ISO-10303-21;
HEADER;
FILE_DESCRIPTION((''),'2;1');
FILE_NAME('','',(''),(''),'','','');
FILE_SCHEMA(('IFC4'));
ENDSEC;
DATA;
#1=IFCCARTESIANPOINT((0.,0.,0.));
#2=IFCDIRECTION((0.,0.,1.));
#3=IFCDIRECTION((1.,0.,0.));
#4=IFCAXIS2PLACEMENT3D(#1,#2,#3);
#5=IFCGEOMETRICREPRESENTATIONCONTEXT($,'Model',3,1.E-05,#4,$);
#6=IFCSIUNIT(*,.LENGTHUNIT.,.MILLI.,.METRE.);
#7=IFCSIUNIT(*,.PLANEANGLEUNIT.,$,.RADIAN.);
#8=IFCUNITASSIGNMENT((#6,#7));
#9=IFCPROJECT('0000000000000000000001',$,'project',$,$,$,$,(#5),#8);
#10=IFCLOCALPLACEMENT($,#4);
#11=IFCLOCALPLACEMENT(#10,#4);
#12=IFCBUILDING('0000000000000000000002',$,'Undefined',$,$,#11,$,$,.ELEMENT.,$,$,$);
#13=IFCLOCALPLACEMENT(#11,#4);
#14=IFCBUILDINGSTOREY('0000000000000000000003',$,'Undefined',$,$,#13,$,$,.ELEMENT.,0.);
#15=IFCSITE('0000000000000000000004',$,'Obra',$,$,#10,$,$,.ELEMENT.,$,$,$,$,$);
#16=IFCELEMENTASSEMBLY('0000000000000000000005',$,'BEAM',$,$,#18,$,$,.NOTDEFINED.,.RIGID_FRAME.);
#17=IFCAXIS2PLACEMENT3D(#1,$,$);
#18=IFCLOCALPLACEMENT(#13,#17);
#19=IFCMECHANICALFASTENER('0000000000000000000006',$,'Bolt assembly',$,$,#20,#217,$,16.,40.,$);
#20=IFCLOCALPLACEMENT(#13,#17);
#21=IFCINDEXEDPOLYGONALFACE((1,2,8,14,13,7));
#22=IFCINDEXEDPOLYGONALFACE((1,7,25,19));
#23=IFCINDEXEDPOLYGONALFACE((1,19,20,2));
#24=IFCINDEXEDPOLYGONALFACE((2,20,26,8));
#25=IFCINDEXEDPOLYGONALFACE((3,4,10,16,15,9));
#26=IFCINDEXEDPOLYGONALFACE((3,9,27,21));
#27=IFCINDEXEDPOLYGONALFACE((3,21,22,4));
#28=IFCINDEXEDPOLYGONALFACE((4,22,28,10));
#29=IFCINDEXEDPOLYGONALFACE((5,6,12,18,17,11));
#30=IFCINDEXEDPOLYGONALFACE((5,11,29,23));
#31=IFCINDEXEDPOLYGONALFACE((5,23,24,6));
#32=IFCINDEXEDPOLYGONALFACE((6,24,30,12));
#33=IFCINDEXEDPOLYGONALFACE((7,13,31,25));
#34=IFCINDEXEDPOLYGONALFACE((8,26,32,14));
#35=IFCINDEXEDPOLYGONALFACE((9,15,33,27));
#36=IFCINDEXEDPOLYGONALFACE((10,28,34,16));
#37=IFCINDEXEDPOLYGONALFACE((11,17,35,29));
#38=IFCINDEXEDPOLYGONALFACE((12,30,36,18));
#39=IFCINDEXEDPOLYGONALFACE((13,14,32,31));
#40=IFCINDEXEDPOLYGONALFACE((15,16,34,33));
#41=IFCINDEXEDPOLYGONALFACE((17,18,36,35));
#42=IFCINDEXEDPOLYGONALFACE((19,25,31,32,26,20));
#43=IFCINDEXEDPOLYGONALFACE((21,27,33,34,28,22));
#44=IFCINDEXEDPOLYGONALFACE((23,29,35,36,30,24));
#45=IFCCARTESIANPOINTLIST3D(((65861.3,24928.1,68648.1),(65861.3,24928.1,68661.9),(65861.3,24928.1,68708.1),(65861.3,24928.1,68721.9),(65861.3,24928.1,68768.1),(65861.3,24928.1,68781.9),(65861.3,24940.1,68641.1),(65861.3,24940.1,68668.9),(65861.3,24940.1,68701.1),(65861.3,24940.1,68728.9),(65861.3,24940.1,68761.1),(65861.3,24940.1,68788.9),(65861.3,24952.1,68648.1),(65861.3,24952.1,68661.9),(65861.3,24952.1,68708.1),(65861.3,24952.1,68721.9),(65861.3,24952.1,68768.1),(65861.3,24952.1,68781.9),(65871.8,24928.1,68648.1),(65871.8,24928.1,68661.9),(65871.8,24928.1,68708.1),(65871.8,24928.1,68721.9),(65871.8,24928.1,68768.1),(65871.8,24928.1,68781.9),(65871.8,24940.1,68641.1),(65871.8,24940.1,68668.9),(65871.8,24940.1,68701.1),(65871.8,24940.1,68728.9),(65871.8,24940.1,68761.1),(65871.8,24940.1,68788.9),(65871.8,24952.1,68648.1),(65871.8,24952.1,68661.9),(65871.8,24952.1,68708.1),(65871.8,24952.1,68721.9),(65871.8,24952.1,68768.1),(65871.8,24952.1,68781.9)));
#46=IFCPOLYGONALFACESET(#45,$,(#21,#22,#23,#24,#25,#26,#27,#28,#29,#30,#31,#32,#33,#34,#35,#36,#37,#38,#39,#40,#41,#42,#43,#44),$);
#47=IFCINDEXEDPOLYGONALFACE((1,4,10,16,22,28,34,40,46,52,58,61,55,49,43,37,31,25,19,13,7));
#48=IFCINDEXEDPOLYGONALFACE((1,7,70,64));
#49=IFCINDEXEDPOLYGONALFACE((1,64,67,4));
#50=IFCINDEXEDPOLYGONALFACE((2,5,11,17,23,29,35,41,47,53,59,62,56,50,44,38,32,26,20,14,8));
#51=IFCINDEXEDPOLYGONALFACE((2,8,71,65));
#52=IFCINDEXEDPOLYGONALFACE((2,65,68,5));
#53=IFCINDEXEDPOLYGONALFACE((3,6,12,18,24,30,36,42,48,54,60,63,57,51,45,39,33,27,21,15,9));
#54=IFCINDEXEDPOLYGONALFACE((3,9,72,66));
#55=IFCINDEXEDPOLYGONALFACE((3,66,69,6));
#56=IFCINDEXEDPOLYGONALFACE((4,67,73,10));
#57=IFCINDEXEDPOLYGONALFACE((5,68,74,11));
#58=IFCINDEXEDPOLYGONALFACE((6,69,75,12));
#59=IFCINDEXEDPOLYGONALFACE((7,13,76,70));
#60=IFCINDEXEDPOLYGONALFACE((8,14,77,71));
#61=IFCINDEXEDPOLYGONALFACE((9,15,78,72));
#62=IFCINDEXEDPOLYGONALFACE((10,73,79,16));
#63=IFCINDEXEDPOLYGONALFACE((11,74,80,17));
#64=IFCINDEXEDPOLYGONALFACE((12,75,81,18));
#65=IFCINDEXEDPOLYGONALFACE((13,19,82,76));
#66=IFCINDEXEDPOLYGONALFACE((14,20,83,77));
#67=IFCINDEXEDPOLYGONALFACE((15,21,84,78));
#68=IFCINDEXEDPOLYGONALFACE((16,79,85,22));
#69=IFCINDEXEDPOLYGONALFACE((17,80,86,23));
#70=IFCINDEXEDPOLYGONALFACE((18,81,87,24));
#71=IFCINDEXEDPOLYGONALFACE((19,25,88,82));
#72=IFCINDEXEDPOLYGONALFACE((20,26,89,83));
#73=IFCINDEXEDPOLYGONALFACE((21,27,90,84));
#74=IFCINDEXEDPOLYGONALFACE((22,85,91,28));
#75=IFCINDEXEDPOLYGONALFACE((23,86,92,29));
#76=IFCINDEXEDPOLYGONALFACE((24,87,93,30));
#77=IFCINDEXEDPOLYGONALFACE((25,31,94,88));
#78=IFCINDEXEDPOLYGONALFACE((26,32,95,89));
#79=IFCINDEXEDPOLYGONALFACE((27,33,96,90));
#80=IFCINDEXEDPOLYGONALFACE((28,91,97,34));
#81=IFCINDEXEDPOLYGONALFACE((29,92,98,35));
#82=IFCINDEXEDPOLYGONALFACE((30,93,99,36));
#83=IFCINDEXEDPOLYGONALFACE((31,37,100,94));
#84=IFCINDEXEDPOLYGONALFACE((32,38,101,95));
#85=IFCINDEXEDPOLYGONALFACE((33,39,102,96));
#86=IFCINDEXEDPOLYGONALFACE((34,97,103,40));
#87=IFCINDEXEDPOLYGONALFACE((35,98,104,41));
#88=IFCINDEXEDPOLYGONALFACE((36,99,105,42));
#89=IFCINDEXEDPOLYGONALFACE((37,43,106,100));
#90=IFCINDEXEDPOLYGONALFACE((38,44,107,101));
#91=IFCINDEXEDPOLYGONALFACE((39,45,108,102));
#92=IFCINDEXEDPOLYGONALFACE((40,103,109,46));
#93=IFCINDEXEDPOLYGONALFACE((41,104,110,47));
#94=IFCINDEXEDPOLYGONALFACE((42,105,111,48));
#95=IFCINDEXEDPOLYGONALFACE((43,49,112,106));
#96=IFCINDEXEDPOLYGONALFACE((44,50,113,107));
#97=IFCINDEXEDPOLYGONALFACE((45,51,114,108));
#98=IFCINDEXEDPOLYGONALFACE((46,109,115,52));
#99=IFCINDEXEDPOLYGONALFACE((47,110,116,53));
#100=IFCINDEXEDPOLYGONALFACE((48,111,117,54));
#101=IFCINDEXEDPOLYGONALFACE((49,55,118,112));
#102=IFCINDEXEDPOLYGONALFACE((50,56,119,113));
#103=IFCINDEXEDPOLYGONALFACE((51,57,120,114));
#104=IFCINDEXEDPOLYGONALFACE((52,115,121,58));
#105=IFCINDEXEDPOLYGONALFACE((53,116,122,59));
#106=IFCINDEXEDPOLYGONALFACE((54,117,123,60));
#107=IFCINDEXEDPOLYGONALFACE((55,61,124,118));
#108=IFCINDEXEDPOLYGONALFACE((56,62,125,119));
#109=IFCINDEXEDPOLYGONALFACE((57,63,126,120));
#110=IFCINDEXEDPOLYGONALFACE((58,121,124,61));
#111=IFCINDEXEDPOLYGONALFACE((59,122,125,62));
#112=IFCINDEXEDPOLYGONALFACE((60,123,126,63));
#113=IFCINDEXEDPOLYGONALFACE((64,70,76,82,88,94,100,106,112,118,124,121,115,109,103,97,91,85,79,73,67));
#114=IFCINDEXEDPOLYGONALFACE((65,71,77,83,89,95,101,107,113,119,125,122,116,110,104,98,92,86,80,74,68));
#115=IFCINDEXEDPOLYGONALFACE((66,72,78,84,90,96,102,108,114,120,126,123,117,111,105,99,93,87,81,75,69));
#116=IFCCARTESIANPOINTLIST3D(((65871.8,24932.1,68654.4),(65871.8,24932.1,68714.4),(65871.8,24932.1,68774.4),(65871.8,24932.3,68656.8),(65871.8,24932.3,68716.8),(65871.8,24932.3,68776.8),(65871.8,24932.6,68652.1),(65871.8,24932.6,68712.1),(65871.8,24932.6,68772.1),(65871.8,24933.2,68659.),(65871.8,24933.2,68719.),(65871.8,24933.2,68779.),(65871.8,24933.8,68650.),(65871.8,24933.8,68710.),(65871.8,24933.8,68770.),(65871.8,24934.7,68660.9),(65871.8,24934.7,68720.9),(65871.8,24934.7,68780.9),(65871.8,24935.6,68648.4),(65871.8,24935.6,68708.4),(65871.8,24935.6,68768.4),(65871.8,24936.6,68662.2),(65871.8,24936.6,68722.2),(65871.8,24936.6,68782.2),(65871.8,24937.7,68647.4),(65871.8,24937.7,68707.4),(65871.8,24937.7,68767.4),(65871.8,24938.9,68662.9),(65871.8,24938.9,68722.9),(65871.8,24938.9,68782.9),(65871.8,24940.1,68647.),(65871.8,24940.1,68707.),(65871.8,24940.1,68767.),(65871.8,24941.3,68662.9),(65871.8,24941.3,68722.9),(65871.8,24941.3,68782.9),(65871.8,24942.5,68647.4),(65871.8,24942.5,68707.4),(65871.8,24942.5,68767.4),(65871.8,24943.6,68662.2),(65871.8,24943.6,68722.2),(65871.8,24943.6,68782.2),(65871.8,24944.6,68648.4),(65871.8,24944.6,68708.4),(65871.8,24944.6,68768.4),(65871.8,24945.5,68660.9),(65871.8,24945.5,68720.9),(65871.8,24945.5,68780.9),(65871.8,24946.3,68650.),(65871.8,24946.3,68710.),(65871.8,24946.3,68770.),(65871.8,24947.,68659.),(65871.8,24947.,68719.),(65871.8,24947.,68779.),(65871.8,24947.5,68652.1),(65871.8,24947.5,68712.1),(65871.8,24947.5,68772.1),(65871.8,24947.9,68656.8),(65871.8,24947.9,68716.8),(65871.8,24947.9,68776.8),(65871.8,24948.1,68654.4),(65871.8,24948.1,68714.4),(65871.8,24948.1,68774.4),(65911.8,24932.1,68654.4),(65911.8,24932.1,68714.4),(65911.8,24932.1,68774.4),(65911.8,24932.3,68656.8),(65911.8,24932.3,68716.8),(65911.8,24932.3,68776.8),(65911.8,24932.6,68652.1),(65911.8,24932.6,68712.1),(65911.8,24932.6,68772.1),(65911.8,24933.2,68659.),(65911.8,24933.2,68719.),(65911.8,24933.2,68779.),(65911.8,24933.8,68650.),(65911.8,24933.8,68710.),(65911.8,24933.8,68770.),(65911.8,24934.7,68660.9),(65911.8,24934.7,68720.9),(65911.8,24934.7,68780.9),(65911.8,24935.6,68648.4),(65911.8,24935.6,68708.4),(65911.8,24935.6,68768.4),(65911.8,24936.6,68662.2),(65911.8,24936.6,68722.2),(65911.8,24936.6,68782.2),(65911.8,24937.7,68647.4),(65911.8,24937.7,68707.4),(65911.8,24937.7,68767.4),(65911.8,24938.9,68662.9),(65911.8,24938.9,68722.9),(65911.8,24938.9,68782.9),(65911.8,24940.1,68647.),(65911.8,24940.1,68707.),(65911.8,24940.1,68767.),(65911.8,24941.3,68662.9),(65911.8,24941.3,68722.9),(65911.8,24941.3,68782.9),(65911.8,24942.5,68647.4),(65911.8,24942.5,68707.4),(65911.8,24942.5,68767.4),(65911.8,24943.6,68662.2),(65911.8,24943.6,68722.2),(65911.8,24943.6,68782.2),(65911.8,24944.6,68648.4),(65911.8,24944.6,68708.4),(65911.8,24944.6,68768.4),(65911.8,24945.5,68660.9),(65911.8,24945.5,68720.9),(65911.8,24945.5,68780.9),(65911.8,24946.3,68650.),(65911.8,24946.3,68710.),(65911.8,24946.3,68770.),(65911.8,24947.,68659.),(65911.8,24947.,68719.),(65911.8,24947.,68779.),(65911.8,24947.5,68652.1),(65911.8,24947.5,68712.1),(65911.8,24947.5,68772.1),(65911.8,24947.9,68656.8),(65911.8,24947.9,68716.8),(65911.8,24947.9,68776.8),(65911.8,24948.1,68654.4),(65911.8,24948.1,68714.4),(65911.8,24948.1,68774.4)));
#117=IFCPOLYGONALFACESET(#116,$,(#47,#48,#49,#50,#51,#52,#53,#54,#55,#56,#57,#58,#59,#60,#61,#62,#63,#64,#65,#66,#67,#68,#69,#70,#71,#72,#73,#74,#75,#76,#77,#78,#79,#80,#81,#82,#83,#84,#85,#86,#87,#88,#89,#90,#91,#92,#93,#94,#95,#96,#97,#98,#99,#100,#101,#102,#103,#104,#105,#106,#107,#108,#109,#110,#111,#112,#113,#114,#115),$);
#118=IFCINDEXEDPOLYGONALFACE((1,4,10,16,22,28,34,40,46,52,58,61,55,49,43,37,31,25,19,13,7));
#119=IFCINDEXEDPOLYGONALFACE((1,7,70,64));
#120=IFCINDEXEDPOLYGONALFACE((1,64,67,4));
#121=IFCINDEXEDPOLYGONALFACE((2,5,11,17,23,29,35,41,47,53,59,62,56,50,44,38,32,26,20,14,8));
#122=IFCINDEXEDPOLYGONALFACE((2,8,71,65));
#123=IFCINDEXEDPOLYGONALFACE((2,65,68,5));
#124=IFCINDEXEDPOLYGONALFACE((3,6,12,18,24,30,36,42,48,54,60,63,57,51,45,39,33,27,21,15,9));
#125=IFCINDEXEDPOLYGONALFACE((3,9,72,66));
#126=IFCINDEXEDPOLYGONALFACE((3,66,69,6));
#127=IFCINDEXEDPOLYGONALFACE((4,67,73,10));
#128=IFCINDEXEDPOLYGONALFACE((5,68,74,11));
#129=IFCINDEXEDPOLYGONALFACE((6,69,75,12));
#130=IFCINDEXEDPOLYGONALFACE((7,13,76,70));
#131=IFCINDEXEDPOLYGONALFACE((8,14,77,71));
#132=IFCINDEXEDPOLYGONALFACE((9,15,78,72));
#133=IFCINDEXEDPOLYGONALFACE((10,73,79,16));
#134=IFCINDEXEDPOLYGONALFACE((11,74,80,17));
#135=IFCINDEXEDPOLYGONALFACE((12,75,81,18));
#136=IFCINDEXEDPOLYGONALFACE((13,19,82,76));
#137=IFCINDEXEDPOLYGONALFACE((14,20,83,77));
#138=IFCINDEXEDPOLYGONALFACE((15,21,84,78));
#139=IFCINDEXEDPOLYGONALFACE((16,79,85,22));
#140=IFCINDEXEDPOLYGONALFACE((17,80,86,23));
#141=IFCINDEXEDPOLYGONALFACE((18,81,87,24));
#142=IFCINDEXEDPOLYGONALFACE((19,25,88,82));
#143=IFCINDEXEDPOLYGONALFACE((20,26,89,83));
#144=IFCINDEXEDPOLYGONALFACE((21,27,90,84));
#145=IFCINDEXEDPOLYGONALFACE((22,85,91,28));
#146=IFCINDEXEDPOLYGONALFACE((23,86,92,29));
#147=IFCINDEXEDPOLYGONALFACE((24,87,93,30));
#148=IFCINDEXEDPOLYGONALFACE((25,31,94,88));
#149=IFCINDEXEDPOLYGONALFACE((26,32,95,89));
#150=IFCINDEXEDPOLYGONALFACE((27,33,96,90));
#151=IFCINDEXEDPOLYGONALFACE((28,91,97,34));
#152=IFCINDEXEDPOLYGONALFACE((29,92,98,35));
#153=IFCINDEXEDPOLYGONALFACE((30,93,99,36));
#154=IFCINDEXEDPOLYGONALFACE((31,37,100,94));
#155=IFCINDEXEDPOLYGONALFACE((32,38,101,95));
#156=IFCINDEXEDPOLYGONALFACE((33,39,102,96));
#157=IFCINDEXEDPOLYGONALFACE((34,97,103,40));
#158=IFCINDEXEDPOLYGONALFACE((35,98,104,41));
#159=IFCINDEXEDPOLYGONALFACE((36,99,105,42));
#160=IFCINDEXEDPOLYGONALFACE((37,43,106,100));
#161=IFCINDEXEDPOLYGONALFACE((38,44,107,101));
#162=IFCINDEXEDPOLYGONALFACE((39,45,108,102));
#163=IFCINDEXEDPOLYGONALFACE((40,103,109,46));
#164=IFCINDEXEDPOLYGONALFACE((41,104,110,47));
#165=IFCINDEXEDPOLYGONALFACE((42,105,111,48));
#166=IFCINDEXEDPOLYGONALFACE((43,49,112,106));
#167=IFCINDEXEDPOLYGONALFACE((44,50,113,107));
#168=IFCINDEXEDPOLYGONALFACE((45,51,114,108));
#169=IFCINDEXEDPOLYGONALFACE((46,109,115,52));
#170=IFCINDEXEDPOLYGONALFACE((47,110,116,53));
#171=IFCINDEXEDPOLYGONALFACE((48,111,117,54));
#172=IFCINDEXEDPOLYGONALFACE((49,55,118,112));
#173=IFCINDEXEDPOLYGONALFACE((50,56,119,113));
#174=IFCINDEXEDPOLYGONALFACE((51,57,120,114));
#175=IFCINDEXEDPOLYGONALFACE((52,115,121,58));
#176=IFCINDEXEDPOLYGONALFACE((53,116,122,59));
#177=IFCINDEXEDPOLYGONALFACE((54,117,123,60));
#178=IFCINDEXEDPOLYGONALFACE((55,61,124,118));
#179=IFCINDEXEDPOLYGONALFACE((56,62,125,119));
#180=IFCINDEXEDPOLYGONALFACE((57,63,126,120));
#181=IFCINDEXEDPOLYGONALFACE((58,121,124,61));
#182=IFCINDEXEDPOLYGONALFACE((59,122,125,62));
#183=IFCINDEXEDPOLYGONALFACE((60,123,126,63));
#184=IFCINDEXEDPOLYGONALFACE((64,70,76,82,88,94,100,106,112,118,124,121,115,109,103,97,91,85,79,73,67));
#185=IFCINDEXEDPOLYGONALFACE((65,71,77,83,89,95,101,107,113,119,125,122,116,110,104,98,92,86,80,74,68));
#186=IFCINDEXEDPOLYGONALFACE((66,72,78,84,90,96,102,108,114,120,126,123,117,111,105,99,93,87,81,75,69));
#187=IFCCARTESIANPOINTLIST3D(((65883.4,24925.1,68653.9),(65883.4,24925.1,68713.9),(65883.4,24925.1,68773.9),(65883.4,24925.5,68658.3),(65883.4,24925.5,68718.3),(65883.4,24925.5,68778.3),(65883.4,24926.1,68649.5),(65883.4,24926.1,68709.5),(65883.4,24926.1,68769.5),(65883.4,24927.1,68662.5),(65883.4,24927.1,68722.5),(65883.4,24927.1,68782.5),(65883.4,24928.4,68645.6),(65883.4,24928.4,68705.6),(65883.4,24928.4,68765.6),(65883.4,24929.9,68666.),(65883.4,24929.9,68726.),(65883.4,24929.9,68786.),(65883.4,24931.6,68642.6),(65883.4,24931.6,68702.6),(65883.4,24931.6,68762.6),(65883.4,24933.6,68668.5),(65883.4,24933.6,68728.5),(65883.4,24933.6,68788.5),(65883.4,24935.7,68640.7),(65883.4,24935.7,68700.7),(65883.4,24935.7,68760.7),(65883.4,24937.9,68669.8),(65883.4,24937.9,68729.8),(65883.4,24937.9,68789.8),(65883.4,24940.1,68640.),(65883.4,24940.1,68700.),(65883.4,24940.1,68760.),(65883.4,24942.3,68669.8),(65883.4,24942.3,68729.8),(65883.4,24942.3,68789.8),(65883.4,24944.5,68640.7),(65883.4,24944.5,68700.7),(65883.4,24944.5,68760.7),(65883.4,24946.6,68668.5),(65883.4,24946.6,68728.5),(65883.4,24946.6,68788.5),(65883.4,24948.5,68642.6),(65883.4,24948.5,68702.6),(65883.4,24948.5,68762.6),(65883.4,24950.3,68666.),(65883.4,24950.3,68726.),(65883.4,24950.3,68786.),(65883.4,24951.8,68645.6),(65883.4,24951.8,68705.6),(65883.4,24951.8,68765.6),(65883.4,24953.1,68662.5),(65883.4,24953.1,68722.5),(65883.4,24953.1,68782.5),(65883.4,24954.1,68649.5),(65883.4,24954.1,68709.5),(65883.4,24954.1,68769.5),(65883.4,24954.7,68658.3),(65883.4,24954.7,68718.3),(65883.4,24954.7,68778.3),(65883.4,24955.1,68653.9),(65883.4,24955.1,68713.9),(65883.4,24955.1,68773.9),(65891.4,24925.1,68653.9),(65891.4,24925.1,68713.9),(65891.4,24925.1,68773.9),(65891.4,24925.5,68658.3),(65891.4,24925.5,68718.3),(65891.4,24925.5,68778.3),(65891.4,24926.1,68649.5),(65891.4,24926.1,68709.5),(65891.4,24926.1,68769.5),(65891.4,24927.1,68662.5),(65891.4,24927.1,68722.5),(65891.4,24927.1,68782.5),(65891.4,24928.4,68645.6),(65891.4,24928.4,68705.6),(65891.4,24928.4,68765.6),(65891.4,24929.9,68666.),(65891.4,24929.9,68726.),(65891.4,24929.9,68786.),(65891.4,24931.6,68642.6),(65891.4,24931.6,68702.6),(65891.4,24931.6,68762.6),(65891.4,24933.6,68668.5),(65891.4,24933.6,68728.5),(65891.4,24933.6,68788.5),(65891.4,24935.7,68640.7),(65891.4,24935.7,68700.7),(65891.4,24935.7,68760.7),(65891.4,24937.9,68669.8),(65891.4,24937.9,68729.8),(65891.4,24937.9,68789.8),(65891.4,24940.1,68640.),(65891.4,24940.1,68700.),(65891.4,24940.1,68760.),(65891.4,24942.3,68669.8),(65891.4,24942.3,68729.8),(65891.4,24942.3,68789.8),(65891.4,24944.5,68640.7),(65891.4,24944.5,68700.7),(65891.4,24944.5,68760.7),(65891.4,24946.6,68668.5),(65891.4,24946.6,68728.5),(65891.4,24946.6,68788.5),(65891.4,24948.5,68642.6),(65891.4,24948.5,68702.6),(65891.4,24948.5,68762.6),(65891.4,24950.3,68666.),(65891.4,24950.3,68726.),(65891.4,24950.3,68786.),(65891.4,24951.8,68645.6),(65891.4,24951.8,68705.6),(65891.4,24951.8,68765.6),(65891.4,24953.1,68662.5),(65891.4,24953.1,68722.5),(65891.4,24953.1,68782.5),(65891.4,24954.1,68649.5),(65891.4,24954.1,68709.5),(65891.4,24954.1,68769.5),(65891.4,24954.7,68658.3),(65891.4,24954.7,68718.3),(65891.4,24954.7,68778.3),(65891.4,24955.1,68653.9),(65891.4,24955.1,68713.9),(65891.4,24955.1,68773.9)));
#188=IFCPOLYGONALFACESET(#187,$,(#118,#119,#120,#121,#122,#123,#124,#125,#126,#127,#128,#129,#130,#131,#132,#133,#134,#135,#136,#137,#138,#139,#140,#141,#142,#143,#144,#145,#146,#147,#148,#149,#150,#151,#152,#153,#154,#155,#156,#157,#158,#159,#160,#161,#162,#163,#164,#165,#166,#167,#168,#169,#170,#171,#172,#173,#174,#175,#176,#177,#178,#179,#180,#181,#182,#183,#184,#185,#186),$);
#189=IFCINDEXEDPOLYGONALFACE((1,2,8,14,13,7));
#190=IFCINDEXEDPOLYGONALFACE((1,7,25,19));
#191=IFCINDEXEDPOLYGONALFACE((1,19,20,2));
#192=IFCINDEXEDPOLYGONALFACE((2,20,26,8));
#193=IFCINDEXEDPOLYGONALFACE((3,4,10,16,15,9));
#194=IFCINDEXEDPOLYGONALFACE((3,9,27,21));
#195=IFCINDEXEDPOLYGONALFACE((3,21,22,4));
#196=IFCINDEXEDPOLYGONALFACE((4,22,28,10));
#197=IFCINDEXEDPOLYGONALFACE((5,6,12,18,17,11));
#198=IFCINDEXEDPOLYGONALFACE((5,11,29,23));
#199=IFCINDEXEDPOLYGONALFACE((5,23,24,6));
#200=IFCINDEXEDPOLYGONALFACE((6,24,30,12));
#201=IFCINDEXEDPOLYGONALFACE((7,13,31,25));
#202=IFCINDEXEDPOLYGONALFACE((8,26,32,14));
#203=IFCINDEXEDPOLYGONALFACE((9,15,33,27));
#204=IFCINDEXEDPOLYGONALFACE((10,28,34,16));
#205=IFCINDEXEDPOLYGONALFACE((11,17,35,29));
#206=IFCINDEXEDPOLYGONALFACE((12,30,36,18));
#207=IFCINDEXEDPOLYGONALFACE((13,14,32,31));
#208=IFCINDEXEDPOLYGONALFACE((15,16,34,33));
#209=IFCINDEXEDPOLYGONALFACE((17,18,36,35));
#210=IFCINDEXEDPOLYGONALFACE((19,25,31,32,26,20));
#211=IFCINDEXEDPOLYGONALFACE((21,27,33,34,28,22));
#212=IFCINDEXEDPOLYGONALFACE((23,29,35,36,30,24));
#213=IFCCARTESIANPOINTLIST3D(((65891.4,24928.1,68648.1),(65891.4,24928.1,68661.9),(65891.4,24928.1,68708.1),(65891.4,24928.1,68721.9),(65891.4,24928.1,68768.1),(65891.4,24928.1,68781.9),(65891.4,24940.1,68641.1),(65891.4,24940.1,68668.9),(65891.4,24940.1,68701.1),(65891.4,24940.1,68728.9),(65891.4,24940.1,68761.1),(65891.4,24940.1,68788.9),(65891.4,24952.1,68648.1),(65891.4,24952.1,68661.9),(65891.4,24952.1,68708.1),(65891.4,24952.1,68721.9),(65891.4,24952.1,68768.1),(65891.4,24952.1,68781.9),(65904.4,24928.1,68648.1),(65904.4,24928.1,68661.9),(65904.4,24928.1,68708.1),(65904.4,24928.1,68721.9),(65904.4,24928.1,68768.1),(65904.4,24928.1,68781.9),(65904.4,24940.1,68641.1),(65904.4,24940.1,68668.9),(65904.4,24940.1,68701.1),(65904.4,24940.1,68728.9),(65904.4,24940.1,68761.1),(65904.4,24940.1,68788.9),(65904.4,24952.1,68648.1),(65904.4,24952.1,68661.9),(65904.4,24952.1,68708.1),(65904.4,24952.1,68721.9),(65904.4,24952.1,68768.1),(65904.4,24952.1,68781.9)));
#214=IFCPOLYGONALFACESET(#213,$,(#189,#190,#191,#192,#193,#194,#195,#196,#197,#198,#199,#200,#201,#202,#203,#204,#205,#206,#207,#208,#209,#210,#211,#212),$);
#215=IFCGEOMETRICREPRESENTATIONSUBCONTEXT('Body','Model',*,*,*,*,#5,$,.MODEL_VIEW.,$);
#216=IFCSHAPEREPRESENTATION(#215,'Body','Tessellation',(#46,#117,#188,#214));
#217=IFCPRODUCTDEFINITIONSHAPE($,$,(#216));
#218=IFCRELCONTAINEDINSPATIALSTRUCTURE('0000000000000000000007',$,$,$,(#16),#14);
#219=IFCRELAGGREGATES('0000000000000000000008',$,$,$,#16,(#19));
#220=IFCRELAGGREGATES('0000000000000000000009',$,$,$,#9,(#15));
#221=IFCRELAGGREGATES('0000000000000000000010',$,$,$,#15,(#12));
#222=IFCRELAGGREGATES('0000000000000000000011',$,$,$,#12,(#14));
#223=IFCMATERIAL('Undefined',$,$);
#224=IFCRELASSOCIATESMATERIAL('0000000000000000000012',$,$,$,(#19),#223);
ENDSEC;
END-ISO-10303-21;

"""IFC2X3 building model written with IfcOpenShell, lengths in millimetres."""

from ifc_helpers import new_model, si_unit, frame, origin_with_axes, origin_2d_with_axis, place, context, subcontext, project, spatial, polyline, circle, outline, extrude, source, transform, mapped, material, element, aggregate, save


model = new_model("IFC2X3")

# Units and contexts
model_context = context("Model", 3, precision=1e-05, world=origin_with_axes())
body_context = subcontext(model_context, "Body", "Model", "MODEL_VIEW")
ifc_project = project(units=[si_unit("LENGTHUNIT", "METRE", prefix="MILLI"), si_unit("PLANEANGLEUNIT", "RADIAN")], contexts=[model_context])

# Site, building, storey
site_placement = place(None, origin_with_axes())
site = spatial("IfcSite", under=ifc_project, at=site_placement, Name="Obra", CompositionType="ELEMENT")
building_placement = place(site_placement, origin_with_axes())
building = spatial("IfcBuilding", under=site, at=building_placement, Name="Undefined", CompositionType="ELEMENT")
storey_placement = place(building_placement, origin_with_axes())
storey = spatial("IfcBuildingStorey", under=building, at=storey_placement, Name="Undefined", CompositionType="ELEMENT", Elevation=0.0)

# Element assembly, mechanical fastener
ifc_material_1 = material(Name="Undefined")
assembly_1_placement = place(storey_placement, origin_with_axes())
assembly_1 = element("IfcElementAssembly", 1, at=assembly_1_placement, inside=storey, Name="BEAM", AssemblyPlace="NOTDEFINED", PredefinedType="RIGID_FRAME")
shared_shape_1 = source(origin_with_axes(), body_context, "Body", "SweptSolid", [
    extrude(outline(polyline([(13.9, 0.0), (6.9, 12.0), (-6.9, 12.0), (-13.9, 0.0), (-6.9, -12.0), (6.9, -12.0), (13.9, 0.0)])), frame((0.0, -19.7, 0.0), z_axis=(0.0, 1.0, 0.0), x_axis=(1.0, 0.0, 0.0)), (0.0, 0.0, 1.0), 10.6),
    extrude(circle(Radius=8.0, at=origin_2d_with_axis()), frame((0.0, -9.1, 0.0), z_axis=(0.0, 1.0, 0.0), x_axis=(1.0, 0.0, 0.0)), (0.0, 0.0, 1.0), 40.0),
    extrude(circle(Radius=15.0, at=origin_2d_with_axis()), frame((0.0, 2.5, 0.0), z_axis=(0.0, 1.0, 0.0), x_axis=(1.0, 0.0, 0.0)), (0.0, 0.0, 1.0), 8.0),
    extrude(outline(polyline([(13.9, 0.0), (6.9, 12.0), (-6.9, 12.0), (-13.9, 0.0), (-6.9, -12.0), (6.9, -12.0), (13.9, 0.0)])), frame((0.0, 10.5, 0.0), z_axis=(0.0, 1.0, 0.0), x_axis=(1.0, 0.0, 0.0)), (0.0, 0.0, 1.0), 13.0),
])
mechanical_fastener_1_placement = place(assembly_1_placement, frame((65880.9, 24990.1, 68835.0), z_axis=(0.000002, -1.0, 0.0), x_axis=(0.0, 0.0, -1.0)))
mechanical_fastener_1 = element("IfcMechanicalFastener", 2, at=mechanical_fastener_1_placement, material=ifc_material_1, Name="Bolt assembly", NominalDiameter=16.0, NominalLength=40.0, context=body_context, shape_type="MappedRepresentation", body=[
    mapped(shared_shape_1, transform((60.0, 0.0, 50.0))),
    mapped(shared_shape_1, transform((120.0, 0.0, 50.0))),
    mapped(shared_shape_1, transform((180.0, 0.0, 50.0))),
])
aggregate(assembly_1, [mechanical_fastener_1])

save(model, "model.ifc")
